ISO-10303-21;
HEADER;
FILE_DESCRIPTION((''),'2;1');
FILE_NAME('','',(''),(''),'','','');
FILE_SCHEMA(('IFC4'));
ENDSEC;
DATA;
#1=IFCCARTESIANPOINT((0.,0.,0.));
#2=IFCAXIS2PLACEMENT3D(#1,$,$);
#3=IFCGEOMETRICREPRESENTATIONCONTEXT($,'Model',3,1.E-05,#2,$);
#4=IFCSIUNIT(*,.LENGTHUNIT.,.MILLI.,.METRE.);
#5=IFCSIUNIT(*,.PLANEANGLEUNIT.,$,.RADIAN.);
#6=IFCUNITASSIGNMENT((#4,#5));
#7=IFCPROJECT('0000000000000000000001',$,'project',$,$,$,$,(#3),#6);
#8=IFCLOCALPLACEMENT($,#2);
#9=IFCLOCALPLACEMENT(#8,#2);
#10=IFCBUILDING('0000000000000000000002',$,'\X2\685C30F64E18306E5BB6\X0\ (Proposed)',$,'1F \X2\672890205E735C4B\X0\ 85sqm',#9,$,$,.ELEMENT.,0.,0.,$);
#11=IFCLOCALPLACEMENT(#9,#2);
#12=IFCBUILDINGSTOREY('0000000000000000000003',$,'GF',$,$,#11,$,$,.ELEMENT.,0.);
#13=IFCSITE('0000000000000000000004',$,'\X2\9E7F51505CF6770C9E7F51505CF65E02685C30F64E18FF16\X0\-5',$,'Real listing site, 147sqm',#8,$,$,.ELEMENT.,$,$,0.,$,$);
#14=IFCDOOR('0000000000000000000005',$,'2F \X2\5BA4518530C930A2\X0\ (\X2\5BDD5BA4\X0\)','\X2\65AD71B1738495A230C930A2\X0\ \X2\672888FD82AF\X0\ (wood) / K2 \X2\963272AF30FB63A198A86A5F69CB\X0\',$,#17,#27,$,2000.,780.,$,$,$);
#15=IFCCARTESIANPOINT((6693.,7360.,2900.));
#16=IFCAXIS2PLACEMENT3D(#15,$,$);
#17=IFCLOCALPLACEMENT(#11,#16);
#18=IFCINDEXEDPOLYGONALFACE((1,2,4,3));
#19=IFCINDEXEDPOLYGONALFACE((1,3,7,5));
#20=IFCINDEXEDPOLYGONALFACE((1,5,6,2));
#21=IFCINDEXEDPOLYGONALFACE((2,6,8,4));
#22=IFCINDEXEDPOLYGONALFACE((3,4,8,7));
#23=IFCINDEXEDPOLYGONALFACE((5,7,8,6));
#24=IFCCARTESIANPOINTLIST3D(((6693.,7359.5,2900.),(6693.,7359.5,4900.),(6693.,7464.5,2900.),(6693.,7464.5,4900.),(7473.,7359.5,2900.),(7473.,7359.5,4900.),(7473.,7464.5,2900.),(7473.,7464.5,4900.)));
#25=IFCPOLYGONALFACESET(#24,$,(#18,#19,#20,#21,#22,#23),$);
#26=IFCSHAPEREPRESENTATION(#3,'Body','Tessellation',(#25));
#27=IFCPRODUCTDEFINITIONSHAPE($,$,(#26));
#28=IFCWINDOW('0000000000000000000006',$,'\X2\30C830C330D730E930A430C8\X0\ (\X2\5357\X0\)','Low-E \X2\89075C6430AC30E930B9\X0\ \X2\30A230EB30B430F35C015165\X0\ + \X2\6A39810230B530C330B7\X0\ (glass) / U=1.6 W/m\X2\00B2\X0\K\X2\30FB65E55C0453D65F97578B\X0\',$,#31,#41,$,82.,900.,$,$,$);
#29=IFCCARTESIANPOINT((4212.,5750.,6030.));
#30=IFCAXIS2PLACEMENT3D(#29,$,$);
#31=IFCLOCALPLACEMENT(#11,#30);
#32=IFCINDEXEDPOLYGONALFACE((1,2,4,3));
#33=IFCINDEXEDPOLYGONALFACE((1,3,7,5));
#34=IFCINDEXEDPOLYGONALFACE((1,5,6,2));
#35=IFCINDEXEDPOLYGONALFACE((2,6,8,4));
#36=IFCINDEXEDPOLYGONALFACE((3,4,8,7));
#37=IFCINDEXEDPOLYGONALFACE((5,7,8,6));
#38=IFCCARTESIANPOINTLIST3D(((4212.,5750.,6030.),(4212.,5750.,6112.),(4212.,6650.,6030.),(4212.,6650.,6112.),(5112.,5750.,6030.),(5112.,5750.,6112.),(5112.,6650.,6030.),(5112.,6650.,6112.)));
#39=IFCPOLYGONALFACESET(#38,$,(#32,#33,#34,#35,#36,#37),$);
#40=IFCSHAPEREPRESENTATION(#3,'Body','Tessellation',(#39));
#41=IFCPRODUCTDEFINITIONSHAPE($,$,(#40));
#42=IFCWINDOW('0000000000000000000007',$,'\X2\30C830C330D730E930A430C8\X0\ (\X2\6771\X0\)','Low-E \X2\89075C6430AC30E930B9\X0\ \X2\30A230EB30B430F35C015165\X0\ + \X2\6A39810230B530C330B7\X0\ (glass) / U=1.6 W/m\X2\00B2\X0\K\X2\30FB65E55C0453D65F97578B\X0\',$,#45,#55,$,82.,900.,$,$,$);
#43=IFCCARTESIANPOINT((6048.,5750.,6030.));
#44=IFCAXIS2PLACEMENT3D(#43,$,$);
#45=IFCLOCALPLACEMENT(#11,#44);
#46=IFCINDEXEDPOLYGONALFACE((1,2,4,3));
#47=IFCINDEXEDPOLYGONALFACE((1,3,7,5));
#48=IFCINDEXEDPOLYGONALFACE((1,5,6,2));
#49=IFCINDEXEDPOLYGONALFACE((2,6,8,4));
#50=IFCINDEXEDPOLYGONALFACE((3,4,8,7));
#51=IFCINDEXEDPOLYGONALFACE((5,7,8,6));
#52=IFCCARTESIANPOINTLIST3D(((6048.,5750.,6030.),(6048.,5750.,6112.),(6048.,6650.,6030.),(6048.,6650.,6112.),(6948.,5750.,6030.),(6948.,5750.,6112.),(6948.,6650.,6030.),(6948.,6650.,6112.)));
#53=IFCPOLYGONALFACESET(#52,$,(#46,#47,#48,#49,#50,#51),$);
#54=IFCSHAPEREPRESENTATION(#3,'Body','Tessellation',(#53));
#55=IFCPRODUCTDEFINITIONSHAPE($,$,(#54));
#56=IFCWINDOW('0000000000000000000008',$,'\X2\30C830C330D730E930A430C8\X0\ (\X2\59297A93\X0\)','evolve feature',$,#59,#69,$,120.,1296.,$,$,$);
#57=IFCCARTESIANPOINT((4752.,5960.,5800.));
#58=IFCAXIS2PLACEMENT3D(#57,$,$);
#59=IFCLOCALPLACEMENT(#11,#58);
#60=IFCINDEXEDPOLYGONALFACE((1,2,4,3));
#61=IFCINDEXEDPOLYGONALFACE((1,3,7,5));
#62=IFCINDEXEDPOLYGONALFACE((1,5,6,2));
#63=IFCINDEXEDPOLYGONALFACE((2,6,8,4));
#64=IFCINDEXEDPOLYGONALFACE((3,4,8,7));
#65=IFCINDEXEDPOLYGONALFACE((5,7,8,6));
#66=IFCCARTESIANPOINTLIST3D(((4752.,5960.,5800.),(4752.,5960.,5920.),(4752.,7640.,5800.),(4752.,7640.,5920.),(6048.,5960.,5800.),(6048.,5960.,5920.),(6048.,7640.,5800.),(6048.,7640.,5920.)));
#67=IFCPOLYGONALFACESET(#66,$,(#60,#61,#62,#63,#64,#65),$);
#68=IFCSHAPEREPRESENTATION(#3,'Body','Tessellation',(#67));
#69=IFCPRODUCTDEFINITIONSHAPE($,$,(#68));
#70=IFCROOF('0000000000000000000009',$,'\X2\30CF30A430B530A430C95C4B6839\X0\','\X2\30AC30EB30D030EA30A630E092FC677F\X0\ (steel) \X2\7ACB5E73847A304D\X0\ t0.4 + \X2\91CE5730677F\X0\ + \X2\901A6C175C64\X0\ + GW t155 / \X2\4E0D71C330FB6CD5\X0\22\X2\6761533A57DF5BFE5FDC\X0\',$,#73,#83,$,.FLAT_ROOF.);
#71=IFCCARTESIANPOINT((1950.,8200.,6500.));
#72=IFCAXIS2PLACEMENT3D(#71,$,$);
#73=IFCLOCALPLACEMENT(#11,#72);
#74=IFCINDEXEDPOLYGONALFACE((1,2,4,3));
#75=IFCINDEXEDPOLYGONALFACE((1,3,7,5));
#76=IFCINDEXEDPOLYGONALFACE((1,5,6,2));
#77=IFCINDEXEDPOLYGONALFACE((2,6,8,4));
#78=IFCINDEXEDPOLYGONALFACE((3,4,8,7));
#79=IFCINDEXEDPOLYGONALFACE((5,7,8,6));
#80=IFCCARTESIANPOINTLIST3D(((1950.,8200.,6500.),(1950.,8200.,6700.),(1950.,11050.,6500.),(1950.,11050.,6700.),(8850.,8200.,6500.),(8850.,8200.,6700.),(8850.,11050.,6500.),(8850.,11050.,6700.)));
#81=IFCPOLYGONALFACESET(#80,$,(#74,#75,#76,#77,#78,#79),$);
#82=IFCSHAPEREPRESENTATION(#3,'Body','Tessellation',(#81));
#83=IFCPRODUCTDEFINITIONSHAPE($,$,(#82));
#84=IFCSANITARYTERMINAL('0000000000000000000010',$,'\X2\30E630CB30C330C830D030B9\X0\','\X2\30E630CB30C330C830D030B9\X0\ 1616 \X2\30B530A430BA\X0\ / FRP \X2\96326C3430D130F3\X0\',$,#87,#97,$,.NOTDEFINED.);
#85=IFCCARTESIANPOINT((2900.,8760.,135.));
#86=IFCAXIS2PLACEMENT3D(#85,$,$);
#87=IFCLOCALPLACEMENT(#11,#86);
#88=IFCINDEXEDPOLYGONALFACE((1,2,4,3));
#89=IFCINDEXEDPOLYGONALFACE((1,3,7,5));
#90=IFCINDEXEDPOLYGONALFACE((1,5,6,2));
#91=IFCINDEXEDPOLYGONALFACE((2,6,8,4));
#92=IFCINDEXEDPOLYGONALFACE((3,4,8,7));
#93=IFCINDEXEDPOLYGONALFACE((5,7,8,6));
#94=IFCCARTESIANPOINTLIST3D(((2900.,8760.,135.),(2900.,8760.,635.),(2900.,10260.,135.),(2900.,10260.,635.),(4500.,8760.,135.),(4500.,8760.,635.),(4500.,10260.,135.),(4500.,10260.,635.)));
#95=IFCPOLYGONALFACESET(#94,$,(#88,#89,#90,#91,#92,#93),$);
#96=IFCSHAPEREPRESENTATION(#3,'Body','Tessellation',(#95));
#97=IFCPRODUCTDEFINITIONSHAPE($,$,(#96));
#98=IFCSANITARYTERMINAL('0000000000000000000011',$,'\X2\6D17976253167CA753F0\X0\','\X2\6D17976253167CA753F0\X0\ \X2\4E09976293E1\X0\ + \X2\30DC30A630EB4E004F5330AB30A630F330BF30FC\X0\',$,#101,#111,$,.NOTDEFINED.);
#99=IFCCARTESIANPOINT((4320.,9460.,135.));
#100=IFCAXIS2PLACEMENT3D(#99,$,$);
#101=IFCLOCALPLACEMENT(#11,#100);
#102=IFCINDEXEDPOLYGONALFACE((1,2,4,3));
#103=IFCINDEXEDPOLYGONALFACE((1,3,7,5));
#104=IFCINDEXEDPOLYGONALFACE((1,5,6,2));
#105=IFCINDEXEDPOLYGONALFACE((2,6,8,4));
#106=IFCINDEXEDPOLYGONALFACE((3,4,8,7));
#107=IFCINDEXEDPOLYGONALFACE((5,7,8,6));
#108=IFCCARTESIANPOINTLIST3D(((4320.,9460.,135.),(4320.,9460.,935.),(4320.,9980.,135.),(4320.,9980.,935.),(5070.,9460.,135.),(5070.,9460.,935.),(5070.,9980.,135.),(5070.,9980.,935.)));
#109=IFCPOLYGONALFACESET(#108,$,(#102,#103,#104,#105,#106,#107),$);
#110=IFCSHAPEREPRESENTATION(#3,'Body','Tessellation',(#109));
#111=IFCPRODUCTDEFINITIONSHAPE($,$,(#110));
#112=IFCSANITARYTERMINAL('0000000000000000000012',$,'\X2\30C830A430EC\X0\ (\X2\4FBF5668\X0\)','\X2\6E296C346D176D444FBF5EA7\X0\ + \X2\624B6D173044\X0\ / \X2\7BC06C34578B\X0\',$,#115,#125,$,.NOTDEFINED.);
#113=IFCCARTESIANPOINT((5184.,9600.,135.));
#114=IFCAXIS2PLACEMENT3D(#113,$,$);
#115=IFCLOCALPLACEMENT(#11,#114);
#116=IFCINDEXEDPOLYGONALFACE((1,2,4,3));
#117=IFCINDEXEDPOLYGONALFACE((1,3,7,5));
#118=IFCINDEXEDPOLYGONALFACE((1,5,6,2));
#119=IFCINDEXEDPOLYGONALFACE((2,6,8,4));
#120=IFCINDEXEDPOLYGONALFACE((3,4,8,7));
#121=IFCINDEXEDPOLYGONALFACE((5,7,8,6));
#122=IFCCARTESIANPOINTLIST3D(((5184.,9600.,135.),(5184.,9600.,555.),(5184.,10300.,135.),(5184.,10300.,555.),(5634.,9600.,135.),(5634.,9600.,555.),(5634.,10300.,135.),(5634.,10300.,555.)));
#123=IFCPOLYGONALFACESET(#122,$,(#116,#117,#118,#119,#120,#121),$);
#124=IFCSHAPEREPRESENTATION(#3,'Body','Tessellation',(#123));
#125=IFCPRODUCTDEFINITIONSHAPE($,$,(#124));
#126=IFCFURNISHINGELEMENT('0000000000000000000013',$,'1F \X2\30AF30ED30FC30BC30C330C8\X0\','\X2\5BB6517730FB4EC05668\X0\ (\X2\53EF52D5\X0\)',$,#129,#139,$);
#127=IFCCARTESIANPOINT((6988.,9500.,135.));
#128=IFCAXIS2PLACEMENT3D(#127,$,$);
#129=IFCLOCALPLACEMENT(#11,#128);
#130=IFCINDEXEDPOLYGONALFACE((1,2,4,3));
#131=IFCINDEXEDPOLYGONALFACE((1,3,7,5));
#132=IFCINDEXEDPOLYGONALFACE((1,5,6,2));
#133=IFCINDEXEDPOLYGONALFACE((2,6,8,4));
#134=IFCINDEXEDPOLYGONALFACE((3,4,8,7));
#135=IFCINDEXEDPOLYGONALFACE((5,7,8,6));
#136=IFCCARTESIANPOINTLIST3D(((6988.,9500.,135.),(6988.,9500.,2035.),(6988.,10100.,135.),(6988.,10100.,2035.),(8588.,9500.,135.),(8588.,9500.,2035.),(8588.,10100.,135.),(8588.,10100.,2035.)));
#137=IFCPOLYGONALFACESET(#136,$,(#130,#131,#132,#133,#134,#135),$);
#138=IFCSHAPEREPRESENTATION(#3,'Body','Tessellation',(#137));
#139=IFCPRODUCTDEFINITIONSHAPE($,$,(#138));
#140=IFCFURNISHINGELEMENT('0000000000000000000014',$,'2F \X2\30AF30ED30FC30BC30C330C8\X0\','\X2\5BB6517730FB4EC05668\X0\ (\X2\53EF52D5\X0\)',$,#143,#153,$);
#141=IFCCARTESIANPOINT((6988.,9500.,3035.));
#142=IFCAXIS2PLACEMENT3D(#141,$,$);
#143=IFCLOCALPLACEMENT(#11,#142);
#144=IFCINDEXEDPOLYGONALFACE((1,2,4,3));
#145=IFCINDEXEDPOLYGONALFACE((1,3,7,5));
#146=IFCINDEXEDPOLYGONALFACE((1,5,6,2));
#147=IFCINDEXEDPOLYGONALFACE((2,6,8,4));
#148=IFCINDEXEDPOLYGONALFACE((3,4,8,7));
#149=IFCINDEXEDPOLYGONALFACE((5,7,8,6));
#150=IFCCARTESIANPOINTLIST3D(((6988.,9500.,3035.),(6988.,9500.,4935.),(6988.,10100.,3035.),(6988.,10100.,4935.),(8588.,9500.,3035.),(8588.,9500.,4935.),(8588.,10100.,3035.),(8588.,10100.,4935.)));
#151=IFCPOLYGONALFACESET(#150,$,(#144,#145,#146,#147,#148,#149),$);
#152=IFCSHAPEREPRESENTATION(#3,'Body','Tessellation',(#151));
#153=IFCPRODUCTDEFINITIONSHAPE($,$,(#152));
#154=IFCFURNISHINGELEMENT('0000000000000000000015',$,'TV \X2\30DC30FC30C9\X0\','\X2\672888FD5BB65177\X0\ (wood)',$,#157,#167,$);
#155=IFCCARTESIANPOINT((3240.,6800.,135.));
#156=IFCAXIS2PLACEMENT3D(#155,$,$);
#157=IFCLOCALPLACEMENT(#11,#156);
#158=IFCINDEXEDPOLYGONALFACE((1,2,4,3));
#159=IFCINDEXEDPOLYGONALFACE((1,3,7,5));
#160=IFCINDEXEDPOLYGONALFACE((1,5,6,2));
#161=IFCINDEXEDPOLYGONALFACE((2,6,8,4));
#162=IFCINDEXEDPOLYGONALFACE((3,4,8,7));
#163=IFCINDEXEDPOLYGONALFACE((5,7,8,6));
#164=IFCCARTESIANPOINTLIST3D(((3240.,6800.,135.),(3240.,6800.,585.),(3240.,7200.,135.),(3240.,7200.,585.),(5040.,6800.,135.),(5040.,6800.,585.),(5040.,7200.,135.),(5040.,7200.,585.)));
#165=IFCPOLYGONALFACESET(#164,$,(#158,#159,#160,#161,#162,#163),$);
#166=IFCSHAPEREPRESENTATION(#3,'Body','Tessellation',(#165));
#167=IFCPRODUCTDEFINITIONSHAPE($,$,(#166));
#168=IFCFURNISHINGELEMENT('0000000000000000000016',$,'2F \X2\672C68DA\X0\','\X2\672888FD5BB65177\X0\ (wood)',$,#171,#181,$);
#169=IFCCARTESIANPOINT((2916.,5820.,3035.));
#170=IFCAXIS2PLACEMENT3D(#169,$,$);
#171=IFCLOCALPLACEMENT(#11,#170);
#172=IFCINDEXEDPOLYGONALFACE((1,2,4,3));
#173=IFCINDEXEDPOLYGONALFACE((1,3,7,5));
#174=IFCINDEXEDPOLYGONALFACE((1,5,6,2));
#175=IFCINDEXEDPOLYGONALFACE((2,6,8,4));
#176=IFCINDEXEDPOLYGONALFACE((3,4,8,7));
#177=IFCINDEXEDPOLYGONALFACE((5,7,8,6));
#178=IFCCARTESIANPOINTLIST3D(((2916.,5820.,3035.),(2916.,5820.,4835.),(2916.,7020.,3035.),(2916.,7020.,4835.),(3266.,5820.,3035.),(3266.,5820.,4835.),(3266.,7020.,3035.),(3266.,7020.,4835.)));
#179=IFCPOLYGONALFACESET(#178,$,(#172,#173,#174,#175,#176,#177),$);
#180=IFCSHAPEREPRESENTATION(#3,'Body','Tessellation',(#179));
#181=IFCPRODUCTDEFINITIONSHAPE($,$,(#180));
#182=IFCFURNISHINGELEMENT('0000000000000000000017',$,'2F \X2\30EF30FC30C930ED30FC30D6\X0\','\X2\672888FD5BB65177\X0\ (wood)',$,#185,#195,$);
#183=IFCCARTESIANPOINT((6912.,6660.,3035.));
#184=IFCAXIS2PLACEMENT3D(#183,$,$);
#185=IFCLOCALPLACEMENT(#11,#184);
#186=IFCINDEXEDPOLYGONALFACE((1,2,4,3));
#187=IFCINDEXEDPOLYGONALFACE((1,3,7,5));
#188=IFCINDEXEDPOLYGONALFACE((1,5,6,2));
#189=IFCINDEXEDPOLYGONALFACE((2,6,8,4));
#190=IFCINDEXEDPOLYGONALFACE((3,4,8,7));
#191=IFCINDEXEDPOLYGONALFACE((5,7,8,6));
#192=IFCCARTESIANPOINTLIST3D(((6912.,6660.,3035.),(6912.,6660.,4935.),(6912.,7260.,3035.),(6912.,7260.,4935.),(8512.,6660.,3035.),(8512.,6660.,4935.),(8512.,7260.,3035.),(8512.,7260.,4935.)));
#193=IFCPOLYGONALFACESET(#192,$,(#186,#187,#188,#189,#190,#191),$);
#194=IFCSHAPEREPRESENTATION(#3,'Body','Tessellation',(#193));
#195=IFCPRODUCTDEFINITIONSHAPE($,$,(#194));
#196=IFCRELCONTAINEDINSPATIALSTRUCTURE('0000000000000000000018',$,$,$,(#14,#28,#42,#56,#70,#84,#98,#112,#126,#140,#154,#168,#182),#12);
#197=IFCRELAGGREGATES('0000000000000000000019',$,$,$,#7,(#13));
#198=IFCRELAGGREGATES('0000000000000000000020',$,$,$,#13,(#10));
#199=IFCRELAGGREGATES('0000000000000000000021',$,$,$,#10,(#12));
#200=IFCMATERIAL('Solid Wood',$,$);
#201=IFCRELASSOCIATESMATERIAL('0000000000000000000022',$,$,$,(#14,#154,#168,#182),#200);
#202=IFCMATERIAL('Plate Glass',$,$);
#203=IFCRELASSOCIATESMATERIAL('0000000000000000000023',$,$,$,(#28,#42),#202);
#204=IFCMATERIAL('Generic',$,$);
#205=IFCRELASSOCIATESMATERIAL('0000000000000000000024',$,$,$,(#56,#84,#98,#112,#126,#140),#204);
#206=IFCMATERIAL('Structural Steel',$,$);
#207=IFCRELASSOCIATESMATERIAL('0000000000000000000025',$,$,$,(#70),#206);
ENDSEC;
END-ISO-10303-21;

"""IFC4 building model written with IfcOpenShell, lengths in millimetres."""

from ifc_helpers import new_model, si_unit, frame, frame_2d, origin, place, context, project, spatial, rectangle, extrude, material, element, save


model = new_model("IFC4")

# Units and contexts
model_context = context("Model", 3, precision=1e-05, world=origin())
ifc_project = project(units=[si_unit("LENGTHUNIT", "METRE", prefix="MILLI"), si_unit("PLANEANGLEUNIT", "RADIAN")], contexts=[model_context])

# Site, building, storey
site_placement = place(None, origin())
site = spatial("IfcSite", under=ifc_project, at=site_placement, Name="鹿児島県鹿児島市桜ヶ丘６-5", ObjectType="Real listing site, 147sqm", CompositionType="ELEMENT", RefElevation=0.0)
building_placement = place(site_placement, origin())
building = spatial("IfcBuilding", under=site, at=building_placement, Name="桜ヶ丘の家 (Proposed)", ObjectType="1F 木造平屋 85sqm", CompositionType="ELEMENT", ElevationOfRefHeight=0.0, ElevationOfTerrain=0.0)
storey_placement = place(building_placement, origin())
storey = spatial("IfcBuildingStorey", under=building, at=storey_placement, Name="GF", CompositionType="ELEMENT", Elevation=0.0)

# Shared definitions
ifc_material_1 = material(Name="Solid Wood")
ifc_material_2 = material(Name="Plate Glass")

# Door
door_1_placement = place(storey_placement, frame((6693.0, 7360.0, 2900.0)))
element("IfcDoor", 1, at=door_1_placement, inside=storey, material=ifc_material_1, Name="2F 室内ドア (寝室)", Description="断熱玄関ドア 木製芯 (wood) / K2 防犯・採風機構", OverallHeight=2000.0, OverallWidth=780.0, context=model_context, shape_type="SweptSolid", body=[
    extrude(rectangle(XDim=780.0, YDim=105.0, at=frame_2d((390.0, 52.0))), frame((6693.0, 7360.0, 2900.0)), (0.0, 0.0, 1.0), 2000.0),
])

# Windows
window_1_placement = place(storey_placement, frame((4212.0, 5750.0, 6030.0)))
element("IfcWindow", 2, at=window_1_placement, inside=storey, material=ifc_material_2, Name="トップライト (南)", Description="Low-E 複層ガラス アルゴン封入 + 樹脂サッシ (glass) / U=1.6 W/m²K・日射取得型", OverallHeight=82.0, OverallWidth=900.0, context=model_context, shape_type="SweptSolid", body=[
    extrude(rectangle(XDim=900.0, YDim=900.0, at=frame_2d((450.0, 450.0))), frame((4212.0, 5750.0, 6030.0)), (0.0, 0.0, 1.0), 82.0),
])
window_2_placement = place(storey_placement, frame((6048.0, 5750.0, 6030.0)))
element("IfcWindow", 3, at=window_2_placement, inside=storey, material=ifc_material_2, Name="トップライト (東)", Description="Low-E 複層ガラス アルゴン封入 + 樹脂サッシ (glass) / U=1.6 W/m²K・日射取得型", OverallHeight=82.0, OverallWidth=900.0, context=model_context, shape_type="SweptSolid", body=[
    extrude(rectangle(XDim=900.0, YDim=900.0, at=frame_2d((450.0, 450.0))), frame((6048.0, 5750.0, 6030.0)), (0.0, 0.0, 1.0), 82.0),
])
ifc_material_3 = material(Name="Generic")
window_3_placement = place(storey_placement, frame((4752.0, 5960.0, 5800.0)))
element("IfcWindow", 4, at=window_3_placement, inside=storey, material=ifc_material_3, Name="トップライト (天窓)", Description="evolve feature", OverallHeight=120.0, OverallWidth=1296.0, context=model_context, shape_type="SweptSolid", body=[
    extrude(rectangle(XDim=1296.0, YDim=1680.0, at=frame_2d((648.0, 840.0))), frame((4752.0, 5960.0, 5800.0)), (0.0, 0.0, 1.0), 120.0),
])

# Roof
ifc_material_4 = material(Name="Structural Steel")
roof_placement = place(storey_placement, frame((1950.0, 8200.0, 6500.0)))
element("IfcRoof", 5, at=roof_placement, inside=storey, material=ifc_material_4, Name="ハイサイド屋根", Description="ガルバリウム鋼板 (steel) 立平葺き t0.4 + 野地板 + 通気層 + GW t155 / 不燃・法22条区域対応", PredefinedType="FLAT_ROOF", context=model_context, shape_type="SweptSolid", body=[
    extrude(rectangle(XDim=6900.0, YDim=2850.0, at=frame_2d((3450.0, 1425.0))), frame((1950.0, 8200.0, 6500.0)), (0.0, 0.0, 1.0), 200.0),
])

# Sanitary terminals
sanitary_terminal_1_placement = place(storey_placement, frame((2900.0, 8760.0, 135.0)))
element("IfcSanitaryTerminal", 6, at=sanitary_terminal_1_placement, inside=storey, material=ifc_material_3, Name="ユニットバス", Description="ユニットバス 1616 サイズ / FRP 防水パン", PredefinedType="NOTDEFINED", context=model_context, shape_type="SweptSolid", body=[
    extrude(rectangle(XDim=1600.0, YDim=1500.0, at=frame_2d((800.0, 750.0))), frame((2900.0, 8760.0, 135.0)), (0.0, 0.0, 1.0), 500.0),
])
sanitary_terminal_2_placement = place(storey_placement, frame((4320.0, 9460.0, 135.0)))
element("IfcSanitaryTerminal", 7, at=sanitary_terminal_2_placement, inside=storey, material=ifc_material_3, Name="洗面化粧台", Description="洗面化粧台 三面鏡 + ボウル一体カウンター", PredefinedType="NOTDEFINED", context=model_context, shape_type="SweptSolid", body=[
    extrude(rectangle(XDim=750.0, YDim=520.0, at=frame_2d((375.0, 260.0))), frame((4320.0, 9460.0, 135.0)), (0.0, 0.0, 1.0), 800.0),
])
sanitary_terminal_3_placement = place(storey_placement, frame((5184.0, 9600.0, 135.0)))
element("IfcSanitaryTerminal", 8, at=sanitary_terminal_3_placement, inside=storey, material=ifc_material_3, Name="トイレ (便器)", Description="温水洗浄便座 + 手洗い / 節水型", PredefinedType="NOTDEFINED", context=model_context, shape_type="SweptSolid", body=[
    extrude(rectangle(XDim=450.0, YDim=700.0, at=frame_2d((225.0, 350.0))), frame((5184.0, 9600.0, 135.0)), (0.0, 0.0, 1.0), 420.0),
])

# Furnishing elements
furnishing_1_placement = place(storey_placement, frame((6988.0, 9500.0, 135.0)))
element("IfcFurnishingElement", 9, at=furnishing_1_placement, inside=storey, material=ifc_material_3, Name="1F クローゼット", Description="家具・什器 (可動)", context=model_context, shape_type="SweptSolid", body=[
    extrude(rectangle(XDim=1600.0, YDim=600.0, at=frame_2d((800.0, 300.0))), frame((6988.0, 9500.0, 135.0)), (0.0, 0.0, 1.0), 1900.0),
])
furnishing_2_placement = place(storey_placement, frame((6988.0, 9500.0, 3035.0)))
element("IfcFurnishingElement", 10, at=furnishing_2_placement, inside=storey, material=ifc_material_3, Name="2F クローゼット", Description="家具・什器 (可動)", context=model_context, shape_type="SweptSolid", body=[
    extrude(rectangle(XDim=1600.0, YDim=600.0, at=frame_2d((800.0, 300.0))), frame((6988.0, 9500.0, 3035.0)), (0.0, 0.0, 1.0), 1900.0),
])
furnishing_3_placement = place(storey_placement, frame((3240.0, 6800.0, 135.0)))
element("IfcFurnishingElement", 11, at=furnishing_3_placement, inside=storey, material=ifc_material_1, Name="TV ボード", Description="木製家具 (wood)", context=model_context, shape_type="SweptSolid", body=[
    extrude(rectangle(XDim=1800.0, YDim=400.0, at=frame_2d((900.0, 200.0))), frame((3240.0, 6800.0, 135.0)), (0.0, 0.0, 1.0), 450.0),
])
furnishing_4_placement = place(storey_placement, frame((2916.0, 5820.0, 3035.0)))
element("IfcFurnishingElement", 12, at=furnishing_4_placement, inside=storey, material=ifc_material_1, Name="2F 本棚", Description="木製家具 (wood)", context=model_context, shape_type="SweptSolid", body=[
    extrude(rectangle(XDim=350.0, YDim=1200.0, at=frame_2d((175.0, 600.0))), frame((2916.0, 5820.0, 3035.0)), (0.0, 0.0, 1.0), 1800.0),
])
furnishing_5_placement = place(storey_placement, frame((6912.0, 6660.0, 3035.0)))
element("IfcFurnishingElement", 13, at=furnishing_5_placement, inside=storey, material=ifc_material_1, Name="2F ワードローブ", Description="木製家具 (wood)", context=model_context, shape_type="SweptSolid", body=[
    extrude(rectangle(XDim=1600.0, YDim=600.0, at=frame_2d((800.0, 300.0))), frame((6912.0, 6660.0, 3035.0)), (0.0, 0.0, 1.0), 1900.0),
])

save(model, "model.ifc")
